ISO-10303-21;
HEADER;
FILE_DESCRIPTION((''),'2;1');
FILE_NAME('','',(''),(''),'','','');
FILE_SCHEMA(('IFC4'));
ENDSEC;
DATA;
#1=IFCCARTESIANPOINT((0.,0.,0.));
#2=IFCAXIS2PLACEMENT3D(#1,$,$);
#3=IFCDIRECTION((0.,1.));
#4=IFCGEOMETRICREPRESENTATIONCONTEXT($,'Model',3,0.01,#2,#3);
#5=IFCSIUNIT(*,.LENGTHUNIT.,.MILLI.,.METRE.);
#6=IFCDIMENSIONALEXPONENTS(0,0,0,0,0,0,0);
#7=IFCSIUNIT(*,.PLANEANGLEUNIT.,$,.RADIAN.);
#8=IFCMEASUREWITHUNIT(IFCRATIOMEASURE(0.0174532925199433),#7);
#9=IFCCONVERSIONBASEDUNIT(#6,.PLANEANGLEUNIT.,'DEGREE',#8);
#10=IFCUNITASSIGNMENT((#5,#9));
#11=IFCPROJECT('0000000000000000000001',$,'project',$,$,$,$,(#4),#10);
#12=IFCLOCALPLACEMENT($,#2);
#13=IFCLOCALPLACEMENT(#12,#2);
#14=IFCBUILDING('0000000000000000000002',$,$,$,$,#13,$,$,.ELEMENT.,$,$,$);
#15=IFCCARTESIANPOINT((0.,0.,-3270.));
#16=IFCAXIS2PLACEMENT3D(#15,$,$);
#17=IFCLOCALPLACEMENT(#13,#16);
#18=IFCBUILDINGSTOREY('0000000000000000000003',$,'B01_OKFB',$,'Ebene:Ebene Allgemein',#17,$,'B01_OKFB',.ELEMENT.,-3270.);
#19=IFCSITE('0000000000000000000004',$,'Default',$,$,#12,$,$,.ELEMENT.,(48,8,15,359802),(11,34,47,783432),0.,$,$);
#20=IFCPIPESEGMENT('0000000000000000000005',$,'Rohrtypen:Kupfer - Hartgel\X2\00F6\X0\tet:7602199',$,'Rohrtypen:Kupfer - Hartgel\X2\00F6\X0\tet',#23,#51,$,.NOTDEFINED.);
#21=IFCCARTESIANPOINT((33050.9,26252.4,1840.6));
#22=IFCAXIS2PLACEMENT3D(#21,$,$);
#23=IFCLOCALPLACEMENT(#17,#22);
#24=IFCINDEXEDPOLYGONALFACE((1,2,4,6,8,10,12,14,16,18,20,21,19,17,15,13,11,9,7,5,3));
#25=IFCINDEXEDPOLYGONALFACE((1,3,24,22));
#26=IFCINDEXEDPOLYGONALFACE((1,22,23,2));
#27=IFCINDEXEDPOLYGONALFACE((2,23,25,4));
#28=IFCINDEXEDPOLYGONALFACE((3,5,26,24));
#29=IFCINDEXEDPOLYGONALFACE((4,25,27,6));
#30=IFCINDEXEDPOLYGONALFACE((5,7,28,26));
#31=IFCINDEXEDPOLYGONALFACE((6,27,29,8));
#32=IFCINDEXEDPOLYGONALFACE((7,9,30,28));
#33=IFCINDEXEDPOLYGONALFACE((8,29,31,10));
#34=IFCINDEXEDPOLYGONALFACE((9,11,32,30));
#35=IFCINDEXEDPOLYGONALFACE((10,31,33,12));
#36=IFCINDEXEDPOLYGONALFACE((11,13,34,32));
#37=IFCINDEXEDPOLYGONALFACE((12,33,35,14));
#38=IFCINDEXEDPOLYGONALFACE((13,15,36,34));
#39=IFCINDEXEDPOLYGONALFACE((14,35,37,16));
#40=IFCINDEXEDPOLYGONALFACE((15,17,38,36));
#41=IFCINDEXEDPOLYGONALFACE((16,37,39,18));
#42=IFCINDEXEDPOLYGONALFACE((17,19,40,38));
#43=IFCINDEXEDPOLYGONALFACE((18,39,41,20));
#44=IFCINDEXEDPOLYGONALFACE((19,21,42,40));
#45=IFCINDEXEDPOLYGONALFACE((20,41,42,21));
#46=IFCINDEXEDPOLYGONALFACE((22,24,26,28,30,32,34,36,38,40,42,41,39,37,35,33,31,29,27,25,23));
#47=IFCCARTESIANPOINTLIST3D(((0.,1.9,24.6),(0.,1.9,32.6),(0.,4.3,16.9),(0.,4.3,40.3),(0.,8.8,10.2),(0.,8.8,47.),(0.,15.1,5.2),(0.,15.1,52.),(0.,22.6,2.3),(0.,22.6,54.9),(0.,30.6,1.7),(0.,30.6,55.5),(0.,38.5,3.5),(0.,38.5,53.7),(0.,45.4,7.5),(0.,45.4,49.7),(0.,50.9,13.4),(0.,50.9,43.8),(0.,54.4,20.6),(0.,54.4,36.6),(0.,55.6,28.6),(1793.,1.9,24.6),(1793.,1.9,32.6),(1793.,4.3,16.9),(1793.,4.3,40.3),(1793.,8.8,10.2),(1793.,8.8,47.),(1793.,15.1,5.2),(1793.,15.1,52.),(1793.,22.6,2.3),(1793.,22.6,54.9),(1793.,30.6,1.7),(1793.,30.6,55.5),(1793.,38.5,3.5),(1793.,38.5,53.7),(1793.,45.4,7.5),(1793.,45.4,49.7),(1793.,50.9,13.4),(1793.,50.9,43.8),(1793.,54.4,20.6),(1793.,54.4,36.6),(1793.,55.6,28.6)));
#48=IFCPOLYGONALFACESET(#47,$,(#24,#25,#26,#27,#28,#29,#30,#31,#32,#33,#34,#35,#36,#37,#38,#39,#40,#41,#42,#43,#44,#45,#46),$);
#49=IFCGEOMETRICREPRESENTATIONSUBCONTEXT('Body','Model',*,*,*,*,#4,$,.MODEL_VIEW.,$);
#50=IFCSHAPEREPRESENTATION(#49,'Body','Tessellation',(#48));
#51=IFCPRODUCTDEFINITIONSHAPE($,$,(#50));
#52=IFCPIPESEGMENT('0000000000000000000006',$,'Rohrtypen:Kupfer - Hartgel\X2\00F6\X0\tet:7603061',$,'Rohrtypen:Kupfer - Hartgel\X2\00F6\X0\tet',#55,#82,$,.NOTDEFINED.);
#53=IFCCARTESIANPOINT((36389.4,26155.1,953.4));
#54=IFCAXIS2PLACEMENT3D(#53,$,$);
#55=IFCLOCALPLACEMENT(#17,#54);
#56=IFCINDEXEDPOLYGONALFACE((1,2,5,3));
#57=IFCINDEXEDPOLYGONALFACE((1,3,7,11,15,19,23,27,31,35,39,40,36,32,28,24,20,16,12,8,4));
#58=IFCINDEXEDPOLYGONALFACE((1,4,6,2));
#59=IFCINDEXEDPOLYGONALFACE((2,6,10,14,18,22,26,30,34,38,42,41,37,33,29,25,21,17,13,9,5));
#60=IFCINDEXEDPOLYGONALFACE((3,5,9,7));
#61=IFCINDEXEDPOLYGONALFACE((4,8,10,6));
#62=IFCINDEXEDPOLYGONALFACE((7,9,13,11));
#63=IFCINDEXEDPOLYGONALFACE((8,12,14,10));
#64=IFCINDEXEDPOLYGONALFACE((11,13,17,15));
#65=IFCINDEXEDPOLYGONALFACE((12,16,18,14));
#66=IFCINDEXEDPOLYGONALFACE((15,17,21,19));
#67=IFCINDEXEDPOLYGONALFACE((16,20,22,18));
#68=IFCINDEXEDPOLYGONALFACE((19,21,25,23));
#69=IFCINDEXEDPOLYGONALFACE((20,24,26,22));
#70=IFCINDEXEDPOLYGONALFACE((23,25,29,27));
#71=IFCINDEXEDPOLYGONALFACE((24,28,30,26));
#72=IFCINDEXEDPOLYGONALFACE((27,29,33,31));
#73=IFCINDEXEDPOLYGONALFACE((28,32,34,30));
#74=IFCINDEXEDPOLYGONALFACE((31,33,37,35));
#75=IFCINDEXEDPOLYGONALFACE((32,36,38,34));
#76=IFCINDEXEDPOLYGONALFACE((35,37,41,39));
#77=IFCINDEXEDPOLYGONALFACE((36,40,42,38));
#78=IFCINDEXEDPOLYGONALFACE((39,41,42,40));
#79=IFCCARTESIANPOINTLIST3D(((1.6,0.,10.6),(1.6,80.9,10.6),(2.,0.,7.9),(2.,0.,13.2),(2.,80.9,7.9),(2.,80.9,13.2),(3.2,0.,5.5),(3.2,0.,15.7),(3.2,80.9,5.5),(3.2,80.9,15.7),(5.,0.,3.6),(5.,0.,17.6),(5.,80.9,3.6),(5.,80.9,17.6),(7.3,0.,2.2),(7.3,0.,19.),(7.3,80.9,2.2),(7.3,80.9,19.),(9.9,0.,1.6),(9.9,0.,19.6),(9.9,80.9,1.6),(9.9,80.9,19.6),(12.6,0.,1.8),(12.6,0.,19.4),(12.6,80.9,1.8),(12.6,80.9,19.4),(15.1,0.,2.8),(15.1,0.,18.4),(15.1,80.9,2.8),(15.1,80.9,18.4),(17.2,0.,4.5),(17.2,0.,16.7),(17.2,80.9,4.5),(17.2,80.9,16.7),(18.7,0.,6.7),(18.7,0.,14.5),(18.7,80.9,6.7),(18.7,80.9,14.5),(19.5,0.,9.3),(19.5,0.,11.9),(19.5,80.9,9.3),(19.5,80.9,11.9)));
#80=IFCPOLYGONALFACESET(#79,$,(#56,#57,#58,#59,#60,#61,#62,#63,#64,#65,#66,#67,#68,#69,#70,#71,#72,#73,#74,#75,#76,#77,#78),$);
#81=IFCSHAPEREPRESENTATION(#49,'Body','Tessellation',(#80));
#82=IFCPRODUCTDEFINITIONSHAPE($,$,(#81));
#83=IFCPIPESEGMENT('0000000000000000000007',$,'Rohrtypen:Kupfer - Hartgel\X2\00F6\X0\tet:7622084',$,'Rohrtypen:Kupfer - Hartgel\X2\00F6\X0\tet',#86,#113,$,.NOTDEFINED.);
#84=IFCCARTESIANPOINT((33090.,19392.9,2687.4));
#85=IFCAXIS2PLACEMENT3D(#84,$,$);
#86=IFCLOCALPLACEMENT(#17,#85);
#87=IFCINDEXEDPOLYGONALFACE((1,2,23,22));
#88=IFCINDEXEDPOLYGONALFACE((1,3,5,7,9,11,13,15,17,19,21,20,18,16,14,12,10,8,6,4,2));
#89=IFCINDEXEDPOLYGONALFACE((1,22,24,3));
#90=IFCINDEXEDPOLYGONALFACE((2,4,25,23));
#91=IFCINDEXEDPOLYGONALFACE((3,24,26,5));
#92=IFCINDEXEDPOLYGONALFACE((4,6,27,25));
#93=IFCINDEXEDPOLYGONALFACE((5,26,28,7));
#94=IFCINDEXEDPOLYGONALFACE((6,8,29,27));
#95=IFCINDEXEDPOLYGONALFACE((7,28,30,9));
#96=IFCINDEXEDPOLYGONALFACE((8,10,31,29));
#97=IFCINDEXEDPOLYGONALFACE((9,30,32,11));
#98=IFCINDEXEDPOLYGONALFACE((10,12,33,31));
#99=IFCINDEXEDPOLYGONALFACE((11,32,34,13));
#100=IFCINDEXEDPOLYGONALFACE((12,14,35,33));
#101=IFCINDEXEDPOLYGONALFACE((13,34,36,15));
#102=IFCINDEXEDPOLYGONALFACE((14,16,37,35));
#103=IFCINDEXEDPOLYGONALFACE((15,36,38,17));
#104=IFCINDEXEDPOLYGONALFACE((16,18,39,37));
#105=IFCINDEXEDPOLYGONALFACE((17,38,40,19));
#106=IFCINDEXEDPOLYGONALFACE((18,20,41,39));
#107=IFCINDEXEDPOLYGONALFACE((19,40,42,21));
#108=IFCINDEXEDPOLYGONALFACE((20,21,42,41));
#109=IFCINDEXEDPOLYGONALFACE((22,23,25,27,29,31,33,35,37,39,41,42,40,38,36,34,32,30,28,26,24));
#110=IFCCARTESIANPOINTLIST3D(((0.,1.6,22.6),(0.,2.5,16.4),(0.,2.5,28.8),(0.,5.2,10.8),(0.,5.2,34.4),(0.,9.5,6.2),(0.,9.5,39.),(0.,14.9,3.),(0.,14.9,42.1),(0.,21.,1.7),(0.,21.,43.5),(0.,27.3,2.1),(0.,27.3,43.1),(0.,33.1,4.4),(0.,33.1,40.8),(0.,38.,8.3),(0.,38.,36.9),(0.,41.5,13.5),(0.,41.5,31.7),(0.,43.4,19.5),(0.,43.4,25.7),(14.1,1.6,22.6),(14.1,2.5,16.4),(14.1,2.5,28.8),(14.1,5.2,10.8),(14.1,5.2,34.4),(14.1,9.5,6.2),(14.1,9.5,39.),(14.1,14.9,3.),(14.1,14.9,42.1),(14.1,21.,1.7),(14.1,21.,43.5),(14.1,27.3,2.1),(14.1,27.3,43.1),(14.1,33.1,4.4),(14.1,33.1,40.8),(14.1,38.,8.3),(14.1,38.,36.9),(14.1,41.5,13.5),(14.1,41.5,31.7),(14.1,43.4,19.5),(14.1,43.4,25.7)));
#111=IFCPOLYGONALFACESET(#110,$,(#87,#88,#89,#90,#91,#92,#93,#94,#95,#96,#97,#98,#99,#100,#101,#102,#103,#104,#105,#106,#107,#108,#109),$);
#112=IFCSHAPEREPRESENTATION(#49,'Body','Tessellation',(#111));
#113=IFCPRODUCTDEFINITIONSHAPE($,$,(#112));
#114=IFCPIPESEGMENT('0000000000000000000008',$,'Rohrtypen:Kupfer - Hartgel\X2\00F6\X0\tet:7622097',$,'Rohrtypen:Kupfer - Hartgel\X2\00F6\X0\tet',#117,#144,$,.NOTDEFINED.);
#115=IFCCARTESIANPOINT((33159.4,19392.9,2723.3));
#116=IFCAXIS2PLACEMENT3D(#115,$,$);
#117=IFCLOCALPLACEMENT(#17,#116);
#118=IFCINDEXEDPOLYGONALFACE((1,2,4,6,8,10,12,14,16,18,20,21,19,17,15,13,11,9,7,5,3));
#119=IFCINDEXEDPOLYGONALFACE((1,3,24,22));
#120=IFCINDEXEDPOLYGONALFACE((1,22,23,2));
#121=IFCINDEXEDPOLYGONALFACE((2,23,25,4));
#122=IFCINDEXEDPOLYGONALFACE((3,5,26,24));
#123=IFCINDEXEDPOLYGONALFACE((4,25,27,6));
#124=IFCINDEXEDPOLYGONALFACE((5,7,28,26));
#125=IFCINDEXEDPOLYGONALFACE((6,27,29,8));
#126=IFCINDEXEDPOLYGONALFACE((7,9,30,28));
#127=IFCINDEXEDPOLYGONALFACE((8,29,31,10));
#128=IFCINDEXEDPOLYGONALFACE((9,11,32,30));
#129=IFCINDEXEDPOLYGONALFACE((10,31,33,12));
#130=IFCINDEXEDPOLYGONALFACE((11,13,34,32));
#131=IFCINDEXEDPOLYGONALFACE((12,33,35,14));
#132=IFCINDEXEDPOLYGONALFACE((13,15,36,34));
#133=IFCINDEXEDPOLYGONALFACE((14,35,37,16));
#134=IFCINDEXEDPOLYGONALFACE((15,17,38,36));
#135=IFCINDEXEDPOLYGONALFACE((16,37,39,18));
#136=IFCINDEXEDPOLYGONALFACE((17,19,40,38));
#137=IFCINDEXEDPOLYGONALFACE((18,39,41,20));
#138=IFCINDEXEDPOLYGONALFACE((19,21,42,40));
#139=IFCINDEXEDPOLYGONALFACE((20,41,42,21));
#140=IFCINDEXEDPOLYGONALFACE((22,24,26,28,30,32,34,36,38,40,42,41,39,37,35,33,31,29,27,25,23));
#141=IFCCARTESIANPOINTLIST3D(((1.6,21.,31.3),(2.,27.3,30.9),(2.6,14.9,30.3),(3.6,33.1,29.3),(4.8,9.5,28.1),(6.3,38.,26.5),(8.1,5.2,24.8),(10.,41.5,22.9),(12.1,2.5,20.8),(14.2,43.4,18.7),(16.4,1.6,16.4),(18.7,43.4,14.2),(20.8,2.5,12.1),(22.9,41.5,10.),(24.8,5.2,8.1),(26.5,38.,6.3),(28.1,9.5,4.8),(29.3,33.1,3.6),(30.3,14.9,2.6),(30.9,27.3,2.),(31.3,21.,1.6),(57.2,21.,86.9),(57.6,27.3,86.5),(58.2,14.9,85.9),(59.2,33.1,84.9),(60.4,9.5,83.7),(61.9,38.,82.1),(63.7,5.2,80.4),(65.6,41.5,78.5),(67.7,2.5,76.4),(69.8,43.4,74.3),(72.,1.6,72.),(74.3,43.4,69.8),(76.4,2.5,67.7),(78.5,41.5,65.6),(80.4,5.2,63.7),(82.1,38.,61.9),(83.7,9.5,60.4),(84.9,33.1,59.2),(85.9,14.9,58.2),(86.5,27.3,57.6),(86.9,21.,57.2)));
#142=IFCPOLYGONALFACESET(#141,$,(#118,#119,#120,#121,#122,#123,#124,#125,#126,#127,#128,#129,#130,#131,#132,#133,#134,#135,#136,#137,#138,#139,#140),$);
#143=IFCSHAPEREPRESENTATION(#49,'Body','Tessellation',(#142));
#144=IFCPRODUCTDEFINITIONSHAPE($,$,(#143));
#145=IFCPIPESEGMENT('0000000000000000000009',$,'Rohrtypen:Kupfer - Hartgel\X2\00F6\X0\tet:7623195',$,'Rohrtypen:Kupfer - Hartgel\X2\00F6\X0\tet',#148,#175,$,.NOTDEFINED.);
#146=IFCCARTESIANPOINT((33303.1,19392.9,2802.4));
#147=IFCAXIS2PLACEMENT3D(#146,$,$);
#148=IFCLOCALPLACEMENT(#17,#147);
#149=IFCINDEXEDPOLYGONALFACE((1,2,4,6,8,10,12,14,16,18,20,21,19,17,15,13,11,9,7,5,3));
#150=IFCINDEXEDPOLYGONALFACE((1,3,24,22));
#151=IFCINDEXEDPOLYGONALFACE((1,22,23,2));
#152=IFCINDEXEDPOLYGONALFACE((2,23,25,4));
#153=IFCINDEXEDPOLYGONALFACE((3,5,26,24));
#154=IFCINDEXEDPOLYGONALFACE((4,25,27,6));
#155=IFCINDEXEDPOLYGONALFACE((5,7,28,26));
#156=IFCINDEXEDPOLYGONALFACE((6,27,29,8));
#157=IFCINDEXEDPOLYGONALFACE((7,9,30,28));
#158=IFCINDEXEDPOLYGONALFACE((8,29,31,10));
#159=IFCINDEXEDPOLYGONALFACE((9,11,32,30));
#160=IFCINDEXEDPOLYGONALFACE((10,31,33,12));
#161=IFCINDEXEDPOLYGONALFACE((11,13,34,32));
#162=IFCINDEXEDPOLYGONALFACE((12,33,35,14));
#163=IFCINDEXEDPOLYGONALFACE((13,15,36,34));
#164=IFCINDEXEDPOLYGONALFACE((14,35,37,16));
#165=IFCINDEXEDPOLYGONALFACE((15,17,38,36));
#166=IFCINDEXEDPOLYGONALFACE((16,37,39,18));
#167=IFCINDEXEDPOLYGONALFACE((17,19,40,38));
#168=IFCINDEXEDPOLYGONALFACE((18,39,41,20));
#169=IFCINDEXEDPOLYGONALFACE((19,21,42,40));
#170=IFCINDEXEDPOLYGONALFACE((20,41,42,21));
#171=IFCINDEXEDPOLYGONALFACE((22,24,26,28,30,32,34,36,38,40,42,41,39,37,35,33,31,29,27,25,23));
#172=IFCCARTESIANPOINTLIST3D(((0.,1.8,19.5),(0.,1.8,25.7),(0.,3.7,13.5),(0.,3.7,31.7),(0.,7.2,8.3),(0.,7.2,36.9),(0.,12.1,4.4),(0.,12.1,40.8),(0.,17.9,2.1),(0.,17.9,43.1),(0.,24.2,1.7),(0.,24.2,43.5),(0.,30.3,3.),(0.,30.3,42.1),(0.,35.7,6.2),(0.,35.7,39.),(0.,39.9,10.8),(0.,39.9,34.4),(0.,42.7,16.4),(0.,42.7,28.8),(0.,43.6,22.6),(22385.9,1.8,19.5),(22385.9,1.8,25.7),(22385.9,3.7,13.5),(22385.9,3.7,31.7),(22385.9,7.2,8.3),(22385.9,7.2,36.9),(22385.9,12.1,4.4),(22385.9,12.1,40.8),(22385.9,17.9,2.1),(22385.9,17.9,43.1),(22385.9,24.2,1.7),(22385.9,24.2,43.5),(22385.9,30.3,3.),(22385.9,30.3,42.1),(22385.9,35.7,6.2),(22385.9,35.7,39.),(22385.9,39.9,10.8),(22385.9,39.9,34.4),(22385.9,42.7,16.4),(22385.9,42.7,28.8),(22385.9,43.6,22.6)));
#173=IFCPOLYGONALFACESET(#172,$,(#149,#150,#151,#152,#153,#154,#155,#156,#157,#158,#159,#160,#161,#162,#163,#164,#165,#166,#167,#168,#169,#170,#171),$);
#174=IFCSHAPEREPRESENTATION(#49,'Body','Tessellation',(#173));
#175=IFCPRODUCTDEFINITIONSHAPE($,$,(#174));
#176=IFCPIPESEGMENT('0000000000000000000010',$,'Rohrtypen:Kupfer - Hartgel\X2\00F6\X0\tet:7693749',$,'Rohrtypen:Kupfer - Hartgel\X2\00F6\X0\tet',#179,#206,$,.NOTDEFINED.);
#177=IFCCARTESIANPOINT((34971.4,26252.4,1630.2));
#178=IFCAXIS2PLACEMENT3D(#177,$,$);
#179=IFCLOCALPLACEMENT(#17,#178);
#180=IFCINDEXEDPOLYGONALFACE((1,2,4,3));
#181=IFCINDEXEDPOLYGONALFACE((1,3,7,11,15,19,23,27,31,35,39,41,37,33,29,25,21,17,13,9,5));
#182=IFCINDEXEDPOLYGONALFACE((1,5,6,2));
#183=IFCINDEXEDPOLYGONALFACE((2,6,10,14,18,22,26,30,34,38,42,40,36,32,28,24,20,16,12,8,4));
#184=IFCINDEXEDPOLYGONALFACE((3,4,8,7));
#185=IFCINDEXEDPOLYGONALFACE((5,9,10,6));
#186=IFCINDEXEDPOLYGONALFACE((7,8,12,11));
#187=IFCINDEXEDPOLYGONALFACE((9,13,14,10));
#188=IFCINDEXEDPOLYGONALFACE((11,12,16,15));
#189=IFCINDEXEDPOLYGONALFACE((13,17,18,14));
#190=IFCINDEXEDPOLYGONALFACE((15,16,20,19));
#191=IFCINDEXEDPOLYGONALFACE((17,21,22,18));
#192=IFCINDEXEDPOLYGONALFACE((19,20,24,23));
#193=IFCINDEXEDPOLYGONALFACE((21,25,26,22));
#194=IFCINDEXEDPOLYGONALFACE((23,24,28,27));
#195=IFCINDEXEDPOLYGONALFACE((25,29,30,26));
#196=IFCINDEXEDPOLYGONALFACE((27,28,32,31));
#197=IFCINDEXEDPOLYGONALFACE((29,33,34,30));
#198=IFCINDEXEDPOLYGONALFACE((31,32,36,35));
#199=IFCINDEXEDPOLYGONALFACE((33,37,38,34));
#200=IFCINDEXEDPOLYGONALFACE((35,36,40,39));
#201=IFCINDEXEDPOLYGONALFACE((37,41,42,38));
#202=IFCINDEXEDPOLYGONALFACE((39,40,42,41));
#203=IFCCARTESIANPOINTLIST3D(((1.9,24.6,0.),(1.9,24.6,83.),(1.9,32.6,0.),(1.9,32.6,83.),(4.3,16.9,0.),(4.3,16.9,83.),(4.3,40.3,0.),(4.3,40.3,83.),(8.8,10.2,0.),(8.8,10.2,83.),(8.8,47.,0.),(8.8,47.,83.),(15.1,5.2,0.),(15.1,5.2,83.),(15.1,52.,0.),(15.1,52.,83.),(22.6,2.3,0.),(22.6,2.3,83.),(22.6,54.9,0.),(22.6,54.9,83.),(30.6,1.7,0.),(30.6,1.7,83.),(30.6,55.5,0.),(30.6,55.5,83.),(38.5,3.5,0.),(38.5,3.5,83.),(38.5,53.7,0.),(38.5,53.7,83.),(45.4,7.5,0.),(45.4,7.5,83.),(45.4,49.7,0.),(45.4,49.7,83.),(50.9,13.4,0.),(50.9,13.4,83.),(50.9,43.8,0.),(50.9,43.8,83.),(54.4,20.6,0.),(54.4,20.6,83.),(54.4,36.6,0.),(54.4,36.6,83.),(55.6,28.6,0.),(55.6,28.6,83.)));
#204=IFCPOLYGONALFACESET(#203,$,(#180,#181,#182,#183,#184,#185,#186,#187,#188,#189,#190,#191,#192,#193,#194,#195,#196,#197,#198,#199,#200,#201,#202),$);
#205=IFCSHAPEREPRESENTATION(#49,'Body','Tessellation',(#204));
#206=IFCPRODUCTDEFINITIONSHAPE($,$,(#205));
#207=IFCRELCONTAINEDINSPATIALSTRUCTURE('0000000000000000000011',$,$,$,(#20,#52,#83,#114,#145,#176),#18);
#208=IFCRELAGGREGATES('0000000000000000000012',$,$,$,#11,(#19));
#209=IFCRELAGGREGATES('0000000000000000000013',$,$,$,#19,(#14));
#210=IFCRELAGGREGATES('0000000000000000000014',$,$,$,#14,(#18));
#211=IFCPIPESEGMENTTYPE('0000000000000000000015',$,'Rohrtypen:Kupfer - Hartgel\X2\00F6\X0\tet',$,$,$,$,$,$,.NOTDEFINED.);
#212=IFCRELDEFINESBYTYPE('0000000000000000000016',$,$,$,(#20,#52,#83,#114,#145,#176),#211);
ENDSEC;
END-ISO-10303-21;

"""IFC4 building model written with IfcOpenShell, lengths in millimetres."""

from ifc_helpers import new_model, entity, si_unit, converted_unit, direction, frame, frame_2d, origin, origin_2d_with_axis, place, context, subcontext, project, spatial, circle, extrude, type_object, element, save


model = new_model("IFC4")

# Units and contexts
model_context = context("Model", 3, precision=0.01, world=origin(), true_north=direction((0.0, 1.0)))
body_context = subcontext(model_context, "Body", "Model", "MODEL_VIEW")
ifc_project = project(units=[si_unit("LENGTHUNIT", "METRE", prefix="MILLI"), converted_unit("PLANEANGLEUNIT", "DEGREE", entity("IfcRatioMeasure", 0.0174532925199433), si_unit("PLANEANGLEUNIT", "RADIAN"), dimensions=[0, 0, 0, 0, 0, 0, 0])], contexts=[model_context])

# Site, building, storey
site_placement = place(None, origin())
site = spatial("IfcSite", under=ifc_project, at=site_placement, Name="Default", CompositionType="ELEMENT", RefLatitude=(48, 8, 15, 359802), RefLongitude=(11, 34, 47, 783432), RefElevation=0.0)
building_placement = place(site_placement, origin())
building = spatial("IfcBuilding", under=site, at=building_placement, CompositionType="ELEMENT")
storey_placement = place(building_placement, frame((0.0, 0.0, -3270.0)))
storey = spatial("IfcBuildingStorey", under=building, at=storey_placement, Name="B01_OKFB", ObjectType="Ebene:Ebene Allgemein", LongName="B01_OKFB", CompositionType="ELEMENT", Elevation=-3270.0)

# Pipe segments
pipe_segment_type = type_object("IfcPipeSegmentType", Name="Rohrtypen:Kupfer - Hartgelötet", PredefinedType="NOTDEFINED")
pipe_segment_1_placement = place(storey_placement, frame((33050.9, 26252.4, 1840.6)))
element("IfcPipeSegment", 1, at=pipe_segment_1_placement, inside=storey, type_object=pipe_segment_type, Name="Rohrtypen:Kupfer - Hartgelötet:7602199", ObjectType="Rohrtypen:Kupfer - Hartgelötet", PredefinedType="NOTDEFINED", context=body_context, shape_type="SweptSolid", body=[
    extrude(circle(Radius=27.0, at=origin_2d_with_axis()), frame((0.0, 28.6, 28.6), z_axis=(1.0, 0.0, 0.0), x_axis=(0.0, 1.0, 0.0)), (0.0, 0.0, 1.0), 1793.0),
])
pipe_segment_2_placement = place(storey_placement, frame((36389.4, 26155.1, 953.4)))
element("IfcPipeSegment", 2, at=pipe_segment_2_placement, inside=storey, type_object=pipe_segment_type, Name="Rohrtypen:Kupfer - Hartgelötet:7603061", ObjectType="Rohrtypen:Kupfer - Hartgelötet", PredefinedType="NOTDEFINED", context=body_context, shape_type="SweptSolid", body=[
    extrude(circle(Radius=9.0, at=origin_2d_with_axis()), frame((10.6, 0.0, 10.6), z_axis=(0.0, 1.0, 0.0), x_axis=(-1.0, 0.0, 0.0)), (0.0, 0.0, 1.0), 80.9),
])
pipe_segment_3_placement = place(storey_placement, frame((33090.0, 19392.9, 2687.4)))
element("IfcPipeSegment", 3, at=pipe_segment_3_placement, inside=storey, type_object=pipe_segment_type, Name="Rohrtypen:Kupfer - Hartgelötet:7622084", ObjectType="Rohrtypen:Kupfer - Hartgelötet", PredefinedType="NOTDEFINED", context=body_context, shape_type="SweptSolid", body=[
    extrude(circle(Radius=21.0, at=origin_2d_with_axis()), frame((0.0, 22.6, 22.6), z_axis=(1.0, 0.0, 0.0), x_axis=(0.0, -1.0, 0.0)), (0.0, 0.0, 1.0), 14.1),
])
pipe_segment_4_placement = place(storey_placement, frame((33159.4, 19392.9, 2723.3)))
element("IfcPipeSegment", 4, at=pipe_segment_4_placement, inside=storey, type_object=pipe_segment_type, Name="Rohrtypen:Kupfer - Hartgelötet:7622097", ObjectType="Rohrtypen:Kupfer - Hartgelötet", PredefinedType="NOTDEFINED", context=body_context, shape_type="SweptSolid", body=[
    extrude(circle(Radius=21.0, at=frame_2d((0.0, 0.0), x_axis=(1.0, 0.0))), frame((16.4, 22.6, 16.4), z_axis=(0.707107, 0.0, 0.707107), x_axis=(0.0, -1.0, 0.0)), (0.0, 0.0, 1.0), 78.6),
])
pipe_segment_5_placement = place(storey_placement, frame((33303.1, 19392.9, 2802.4)))
element("IfcPipeSegment", 5, at=pipe_segment_5_placement, inside=storey, type_object=pipe_segment_type, Name="Rohrtypen:Kupfer - Hartgelötet:7623195", ObjectType="Rohrtypen:Kupfer - Hartgelötet", PredefinedType="NOTDEFINED", context=body_context, shape_type="SweptSolid", body=[
    extrude(circle(Radius=21.0, at=frame_2d((0.0, 0.0), x_axis=(1.0, 0.0))), frame((0.0, 22.6, 22.6), z_axis=(1.0, 0.0, 0.0), x_axis=(0.0, 1.0, 0.0)), (0.0, 0.0, 1.0), 22385.9),
])
pipe_segment_6_placement = place(storey_placement, frame((34971.4, 26252.4, 1630.2)))
element("IfcPipeSegment", 6, at=pipe_segment_6_placement, inside=storey, type_object=pipe_segment_type, Name="Rohrtypen:Kupfer - Hartgelötet:7693749", ObjectType="Rohrtypen:Kupfer - Hartgelötet", PredefinedType="NOTDEFINED", context=body_context, shape_type="SweptSolid", body=[
    extrude(circle(Radius=27.0, at=origin_2d_with_axis()), frame((28.6, 28.6, 0.0)), (0.0, 0.0, 1.0), 83.0),
])

save(model, "model.ifc")
